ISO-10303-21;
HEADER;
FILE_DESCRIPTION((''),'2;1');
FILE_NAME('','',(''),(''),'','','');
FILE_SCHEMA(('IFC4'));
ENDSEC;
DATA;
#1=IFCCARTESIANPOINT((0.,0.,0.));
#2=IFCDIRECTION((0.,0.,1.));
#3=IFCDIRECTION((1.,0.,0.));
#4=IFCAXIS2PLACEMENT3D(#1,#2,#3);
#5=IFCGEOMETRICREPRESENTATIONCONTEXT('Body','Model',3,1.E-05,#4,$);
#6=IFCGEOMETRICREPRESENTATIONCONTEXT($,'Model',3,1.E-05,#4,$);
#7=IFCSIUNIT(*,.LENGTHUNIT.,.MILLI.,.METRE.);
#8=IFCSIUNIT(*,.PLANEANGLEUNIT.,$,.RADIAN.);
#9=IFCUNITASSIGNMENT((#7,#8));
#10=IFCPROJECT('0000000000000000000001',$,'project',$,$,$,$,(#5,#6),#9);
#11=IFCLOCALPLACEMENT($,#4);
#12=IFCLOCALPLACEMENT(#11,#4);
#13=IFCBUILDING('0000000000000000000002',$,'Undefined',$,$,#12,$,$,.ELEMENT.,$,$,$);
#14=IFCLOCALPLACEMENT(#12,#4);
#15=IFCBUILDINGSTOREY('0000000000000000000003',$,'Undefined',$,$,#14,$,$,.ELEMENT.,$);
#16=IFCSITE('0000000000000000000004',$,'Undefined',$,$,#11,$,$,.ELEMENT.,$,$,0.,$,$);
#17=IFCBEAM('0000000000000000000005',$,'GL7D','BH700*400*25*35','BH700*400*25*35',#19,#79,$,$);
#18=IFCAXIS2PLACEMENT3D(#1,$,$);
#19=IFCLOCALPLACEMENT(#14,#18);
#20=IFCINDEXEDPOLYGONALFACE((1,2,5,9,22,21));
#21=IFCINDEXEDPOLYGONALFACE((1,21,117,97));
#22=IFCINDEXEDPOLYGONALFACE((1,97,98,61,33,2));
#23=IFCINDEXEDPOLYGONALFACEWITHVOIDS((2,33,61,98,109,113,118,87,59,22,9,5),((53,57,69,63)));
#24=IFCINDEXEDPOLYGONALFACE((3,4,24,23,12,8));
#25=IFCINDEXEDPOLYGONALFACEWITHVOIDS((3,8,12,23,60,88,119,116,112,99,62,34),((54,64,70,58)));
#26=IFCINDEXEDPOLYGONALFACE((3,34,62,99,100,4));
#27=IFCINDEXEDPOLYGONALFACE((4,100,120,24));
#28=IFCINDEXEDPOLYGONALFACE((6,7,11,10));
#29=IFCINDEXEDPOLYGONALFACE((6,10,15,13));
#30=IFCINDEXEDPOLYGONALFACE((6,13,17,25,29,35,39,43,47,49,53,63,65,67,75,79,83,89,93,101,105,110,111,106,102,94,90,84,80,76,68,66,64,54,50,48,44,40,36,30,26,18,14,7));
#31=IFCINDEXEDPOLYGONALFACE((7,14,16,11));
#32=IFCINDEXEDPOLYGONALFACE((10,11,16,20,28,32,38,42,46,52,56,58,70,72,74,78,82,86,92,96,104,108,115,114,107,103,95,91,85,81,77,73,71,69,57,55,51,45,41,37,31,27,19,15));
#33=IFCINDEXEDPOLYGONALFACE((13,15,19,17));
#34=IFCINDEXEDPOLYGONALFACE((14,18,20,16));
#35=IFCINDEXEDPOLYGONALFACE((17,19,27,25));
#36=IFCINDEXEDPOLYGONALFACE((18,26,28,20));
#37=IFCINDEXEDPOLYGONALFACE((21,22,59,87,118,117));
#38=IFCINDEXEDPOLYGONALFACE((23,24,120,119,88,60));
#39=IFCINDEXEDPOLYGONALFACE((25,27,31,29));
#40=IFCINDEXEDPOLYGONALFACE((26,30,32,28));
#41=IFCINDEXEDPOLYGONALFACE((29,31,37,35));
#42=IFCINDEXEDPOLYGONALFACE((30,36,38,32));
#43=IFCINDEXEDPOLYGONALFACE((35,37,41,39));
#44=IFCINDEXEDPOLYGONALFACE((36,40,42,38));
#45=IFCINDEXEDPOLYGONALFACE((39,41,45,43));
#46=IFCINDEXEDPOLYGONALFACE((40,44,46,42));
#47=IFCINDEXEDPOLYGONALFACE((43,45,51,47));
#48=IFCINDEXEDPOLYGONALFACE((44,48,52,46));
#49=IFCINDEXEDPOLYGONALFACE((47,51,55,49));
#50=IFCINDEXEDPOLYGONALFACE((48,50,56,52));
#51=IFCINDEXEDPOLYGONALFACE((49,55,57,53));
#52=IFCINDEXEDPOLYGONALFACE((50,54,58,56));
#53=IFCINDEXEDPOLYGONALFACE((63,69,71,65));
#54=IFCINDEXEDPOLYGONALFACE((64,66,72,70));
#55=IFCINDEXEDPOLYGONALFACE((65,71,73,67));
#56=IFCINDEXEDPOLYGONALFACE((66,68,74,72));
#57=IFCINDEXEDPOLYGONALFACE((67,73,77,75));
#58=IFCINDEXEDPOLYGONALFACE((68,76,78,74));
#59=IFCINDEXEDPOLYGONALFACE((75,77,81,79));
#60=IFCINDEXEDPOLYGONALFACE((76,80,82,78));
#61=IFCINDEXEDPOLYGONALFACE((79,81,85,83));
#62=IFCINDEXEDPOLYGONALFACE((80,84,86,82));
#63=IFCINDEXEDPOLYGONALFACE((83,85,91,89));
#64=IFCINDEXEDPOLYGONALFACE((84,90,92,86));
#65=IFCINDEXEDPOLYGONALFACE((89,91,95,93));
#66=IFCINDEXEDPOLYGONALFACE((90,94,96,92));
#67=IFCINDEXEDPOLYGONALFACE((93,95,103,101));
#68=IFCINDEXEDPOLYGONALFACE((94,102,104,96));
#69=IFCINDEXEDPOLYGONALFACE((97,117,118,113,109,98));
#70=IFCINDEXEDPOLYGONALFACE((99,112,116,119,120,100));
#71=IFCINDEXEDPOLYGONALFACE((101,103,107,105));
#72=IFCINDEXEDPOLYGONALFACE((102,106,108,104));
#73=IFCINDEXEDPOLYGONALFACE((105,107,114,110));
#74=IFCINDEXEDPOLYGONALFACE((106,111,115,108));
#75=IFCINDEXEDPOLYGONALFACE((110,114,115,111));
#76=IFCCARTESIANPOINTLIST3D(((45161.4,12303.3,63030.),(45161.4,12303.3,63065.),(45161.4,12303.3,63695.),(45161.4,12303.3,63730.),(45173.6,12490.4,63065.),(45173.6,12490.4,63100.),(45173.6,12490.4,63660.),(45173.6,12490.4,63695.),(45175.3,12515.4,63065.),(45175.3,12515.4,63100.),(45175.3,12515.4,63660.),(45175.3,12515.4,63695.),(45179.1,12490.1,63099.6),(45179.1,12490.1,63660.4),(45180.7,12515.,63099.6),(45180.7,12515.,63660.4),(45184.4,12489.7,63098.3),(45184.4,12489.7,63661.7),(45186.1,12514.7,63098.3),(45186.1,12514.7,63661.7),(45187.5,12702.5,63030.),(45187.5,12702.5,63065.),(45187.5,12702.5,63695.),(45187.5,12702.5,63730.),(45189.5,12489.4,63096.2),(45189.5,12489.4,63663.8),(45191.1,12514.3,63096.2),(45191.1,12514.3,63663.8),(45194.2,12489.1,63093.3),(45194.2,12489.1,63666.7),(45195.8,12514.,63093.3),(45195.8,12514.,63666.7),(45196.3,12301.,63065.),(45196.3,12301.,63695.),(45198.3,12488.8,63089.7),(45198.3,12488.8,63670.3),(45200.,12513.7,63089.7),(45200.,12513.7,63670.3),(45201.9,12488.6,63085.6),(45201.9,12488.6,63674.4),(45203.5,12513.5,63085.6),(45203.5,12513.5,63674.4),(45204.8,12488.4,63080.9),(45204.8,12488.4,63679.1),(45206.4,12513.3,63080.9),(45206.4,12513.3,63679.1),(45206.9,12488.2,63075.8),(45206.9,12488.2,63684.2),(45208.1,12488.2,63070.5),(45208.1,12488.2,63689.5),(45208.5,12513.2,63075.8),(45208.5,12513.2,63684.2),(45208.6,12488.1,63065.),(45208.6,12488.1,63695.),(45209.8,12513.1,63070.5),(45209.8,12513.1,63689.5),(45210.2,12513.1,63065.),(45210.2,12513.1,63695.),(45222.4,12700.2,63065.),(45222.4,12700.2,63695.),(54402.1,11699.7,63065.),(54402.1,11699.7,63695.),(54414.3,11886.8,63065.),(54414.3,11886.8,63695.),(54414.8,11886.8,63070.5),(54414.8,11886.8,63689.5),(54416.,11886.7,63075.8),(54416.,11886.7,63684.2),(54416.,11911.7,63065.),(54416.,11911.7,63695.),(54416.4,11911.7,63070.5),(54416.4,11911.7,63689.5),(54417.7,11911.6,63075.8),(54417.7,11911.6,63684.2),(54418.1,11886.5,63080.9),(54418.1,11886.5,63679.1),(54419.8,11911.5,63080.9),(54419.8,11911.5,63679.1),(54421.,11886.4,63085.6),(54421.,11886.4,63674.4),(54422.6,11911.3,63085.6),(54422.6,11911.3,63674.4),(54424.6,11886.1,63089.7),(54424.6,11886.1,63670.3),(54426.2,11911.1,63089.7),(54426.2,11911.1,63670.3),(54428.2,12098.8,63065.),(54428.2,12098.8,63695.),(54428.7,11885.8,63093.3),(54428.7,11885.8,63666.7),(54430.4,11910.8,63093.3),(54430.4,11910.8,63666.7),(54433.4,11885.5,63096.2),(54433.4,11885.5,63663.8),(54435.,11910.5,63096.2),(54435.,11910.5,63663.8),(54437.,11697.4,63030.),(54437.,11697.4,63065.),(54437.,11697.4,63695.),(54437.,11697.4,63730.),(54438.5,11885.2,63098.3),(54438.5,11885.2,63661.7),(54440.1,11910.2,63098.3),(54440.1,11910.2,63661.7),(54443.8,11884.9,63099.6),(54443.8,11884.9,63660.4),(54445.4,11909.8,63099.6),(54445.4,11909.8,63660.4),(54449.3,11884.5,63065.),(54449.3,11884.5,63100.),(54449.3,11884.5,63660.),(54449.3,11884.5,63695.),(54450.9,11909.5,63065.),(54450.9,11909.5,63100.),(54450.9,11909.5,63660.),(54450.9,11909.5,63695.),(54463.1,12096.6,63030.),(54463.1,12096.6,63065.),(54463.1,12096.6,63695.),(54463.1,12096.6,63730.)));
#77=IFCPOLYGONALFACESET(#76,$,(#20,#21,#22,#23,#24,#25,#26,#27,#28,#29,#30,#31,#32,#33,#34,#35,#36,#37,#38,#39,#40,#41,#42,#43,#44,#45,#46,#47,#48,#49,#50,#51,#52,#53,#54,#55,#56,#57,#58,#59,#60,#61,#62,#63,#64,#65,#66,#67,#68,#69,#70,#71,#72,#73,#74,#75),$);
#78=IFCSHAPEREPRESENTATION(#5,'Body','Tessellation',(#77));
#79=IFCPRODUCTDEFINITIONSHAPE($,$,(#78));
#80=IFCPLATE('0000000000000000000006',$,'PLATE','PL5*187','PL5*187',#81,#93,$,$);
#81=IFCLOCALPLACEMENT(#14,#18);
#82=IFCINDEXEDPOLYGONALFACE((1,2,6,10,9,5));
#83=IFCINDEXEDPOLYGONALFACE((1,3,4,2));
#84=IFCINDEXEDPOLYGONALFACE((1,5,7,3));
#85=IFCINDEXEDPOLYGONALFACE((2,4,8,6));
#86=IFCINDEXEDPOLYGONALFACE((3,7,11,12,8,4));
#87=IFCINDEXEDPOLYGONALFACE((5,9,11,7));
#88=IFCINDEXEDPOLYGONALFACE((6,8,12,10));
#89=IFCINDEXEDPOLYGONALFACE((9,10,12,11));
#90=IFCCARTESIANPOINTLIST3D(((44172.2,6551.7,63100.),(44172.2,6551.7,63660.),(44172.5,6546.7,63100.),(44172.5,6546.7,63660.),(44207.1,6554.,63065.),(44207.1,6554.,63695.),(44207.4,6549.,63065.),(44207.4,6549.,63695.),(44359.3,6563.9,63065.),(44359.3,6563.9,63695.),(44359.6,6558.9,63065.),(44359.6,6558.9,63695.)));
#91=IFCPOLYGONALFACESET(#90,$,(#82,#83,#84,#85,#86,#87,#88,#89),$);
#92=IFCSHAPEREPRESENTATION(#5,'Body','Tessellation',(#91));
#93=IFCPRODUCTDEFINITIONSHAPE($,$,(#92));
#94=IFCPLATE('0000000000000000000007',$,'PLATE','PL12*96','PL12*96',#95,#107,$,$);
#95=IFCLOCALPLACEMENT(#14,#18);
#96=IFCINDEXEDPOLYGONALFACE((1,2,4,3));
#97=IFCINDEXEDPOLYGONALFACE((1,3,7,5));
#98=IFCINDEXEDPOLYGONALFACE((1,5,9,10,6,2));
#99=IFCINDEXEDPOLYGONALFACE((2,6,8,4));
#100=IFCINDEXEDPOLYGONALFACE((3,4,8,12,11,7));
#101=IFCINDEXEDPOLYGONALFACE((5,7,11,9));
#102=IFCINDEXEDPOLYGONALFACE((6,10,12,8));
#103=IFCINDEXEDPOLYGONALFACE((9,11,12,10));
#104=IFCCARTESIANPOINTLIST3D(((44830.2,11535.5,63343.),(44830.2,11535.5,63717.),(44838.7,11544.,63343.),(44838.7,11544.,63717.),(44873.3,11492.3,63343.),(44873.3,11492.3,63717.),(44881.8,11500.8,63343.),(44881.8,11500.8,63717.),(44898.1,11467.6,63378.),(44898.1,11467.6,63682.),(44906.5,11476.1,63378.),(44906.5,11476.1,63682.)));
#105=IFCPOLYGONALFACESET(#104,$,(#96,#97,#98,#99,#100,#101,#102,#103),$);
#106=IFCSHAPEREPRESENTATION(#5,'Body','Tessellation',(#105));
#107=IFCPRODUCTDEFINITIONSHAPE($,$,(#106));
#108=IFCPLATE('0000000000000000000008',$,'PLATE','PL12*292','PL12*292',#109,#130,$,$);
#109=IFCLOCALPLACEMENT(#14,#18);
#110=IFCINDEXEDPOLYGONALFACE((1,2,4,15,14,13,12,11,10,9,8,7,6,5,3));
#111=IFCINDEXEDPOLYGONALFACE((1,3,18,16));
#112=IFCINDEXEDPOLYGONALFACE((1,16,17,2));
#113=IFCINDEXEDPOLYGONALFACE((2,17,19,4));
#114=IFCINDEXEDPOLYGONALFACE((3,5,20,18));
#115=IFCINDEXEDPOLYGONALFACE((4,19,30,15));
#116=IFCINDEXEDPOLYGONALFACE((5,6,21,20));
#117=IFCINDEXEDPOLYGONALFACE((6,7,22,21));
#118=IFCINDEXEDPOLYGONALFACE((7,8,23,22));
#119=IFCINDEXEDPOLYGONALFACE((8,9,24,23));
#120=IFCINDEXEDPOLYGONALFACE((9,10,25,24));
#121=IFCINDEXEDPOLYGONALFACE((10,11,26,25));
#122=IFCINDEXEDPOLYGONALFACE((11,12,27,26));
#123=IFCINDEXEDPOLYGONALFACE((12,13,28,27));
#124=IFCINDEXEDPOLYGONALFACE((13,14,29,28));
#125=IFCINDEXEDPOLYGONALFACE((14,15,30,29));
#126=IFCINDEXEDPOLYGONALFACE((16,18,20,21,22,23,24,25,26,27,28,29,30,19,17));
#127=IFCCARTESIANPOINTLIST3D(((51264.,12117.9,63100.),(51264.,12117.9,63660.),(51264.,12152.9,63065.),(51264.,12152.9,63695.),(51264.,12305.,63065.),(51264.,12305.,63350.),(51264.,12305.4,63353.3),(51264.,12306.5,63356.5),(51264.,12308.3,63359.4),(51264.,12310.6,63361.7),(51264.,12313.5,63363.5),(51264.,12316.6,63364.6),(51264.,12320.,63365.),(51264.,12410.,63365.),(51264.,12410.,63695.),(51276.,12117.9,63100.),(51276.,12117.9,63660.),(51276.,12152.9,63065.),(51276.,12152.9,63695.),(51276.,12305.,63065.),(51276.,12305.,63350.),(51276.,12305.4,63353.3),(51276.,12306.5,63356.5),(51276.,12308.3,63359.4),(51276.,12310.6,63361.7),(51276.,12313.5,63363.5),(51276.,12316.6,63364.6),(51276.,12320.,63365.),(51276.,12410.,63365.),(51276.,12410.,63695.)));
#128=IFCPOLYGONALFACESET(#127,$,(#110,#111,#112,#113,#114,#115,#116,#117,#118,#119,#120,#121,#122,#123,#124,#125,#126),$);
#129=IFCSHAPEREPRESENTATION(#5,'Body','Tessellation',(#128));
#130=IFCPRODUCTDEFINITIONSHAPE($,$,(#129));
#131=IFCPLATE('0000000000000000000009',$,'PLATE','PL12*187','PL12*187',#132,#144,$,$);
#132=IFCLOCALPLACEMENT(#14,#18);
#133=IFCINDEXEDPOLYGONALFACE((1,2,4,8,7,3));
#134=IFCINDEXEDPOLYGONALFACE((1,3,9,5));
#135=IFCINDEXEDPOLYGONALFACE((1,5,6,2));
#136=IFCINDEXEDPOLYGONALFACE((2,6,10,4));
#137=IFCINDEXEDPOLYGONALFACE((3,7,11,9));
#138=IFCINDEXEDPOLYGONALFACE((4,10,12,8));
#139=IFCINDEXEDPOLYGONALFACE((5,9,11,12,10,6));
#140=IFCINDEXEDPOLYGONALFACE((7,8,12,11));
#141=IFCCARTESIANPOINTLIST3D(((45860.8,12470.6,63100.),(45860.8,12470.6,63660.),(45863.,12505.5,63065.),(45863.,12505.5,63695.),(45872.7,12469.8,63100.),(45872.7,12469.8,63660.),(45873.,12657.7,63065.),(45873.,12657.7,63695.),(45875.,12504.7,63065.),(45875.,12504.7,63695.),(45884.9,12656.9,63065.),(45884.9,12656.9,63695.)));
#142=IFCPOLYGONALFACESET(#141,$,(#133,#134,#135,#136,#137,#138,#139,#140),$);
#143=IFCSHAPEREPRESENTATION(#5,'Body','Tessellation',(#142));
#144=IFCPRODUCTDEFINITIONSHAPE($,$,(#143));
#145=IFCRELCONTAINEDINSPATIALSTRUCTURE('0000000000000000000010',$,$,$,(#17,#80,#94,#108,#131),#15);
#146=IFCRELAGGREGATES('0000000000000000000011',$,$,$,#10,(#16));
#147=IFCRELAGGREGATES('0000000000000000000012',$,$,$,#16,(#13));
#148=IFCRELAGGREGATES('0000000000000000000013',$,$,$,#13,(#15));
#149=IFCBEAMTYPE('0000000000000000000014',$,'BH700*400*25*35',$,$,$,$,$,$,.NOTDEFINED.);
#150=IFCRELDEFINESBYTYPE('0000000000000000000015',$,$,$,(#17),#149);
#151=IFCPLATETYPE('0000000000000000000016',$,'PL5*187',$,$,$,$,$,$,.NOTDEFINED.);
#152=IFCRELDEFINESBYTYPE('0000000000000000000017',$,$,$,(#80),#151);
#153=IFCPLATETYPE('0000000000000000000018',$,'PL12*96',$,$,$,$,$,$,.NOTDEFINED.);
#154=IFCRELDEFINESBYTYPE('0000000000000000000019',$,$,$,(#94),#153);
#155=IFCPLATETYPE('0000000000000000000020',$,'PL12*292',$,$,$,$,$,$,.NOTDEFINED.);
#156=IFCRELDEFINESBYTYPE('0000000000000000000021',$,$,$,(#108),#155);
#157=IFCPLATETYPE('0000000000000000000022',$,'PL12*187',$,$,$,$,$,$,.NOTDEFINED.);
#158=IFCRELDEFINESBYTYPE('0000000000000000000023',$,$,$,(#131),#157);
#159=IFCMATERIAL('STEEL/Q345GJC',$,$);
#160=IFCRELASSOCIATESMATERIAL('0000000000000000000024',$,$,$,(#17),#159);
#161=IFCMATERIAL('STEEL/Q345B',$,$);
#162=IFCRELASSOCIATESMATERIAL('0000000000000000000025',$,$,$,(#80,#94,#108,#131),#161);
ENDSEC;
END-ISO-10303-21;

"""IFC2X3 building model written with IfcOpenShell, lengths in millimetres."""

from ifc_helpers import new_model, si_unit, frame, origin_with_axes, origin_2d_with_axis, place, context, project, spatial, polyline, i_section, outline, extrude, material, type_object, element, save


model = new_model("IFC2X3")

# Units and contexts
model_context_1 = context("Model", 3, precision=1e-05, world=origin_with_axes(), identifier="Body")
model_context_2 = context("Model", 3, precision=1e-05, world=origin_with_axes())
ifc_project = project(units=[si_unit("LENGTHUNIT", "METRE", prefix="MILLI"), si_unit("PLANEANGLEUNIT", "RADIAN")], contexts=[model_context_1, model_context_2])

# Site, building, storey
site_placement = place(None, origin_with_axes())
site = spatial("IfcSite", under=ifc_project, at=site_placement, Name="Undefined", CompositionType="ELEMENT", RefElevation=0.0)
building_placement = place(site_placement, origin_with_axes())
building = spatial("IfcBuilding", under=site, at=building_placement, Name="Undefined", CompositionType="ELEMENT")
storey_placement = place(building_placement, origin_with_axes())
storey = spatial("IfcBuildingStorey", under=building, at=storey_placement, Name="Undefined", CompositionType="ELEMENT")

# Shared definitions
ifc_material_1 = material(Name="STEEL/Q345B")

# Shared definitions
ifc_material_2 = material(Name="STEEL/Q345GJC")

# Beam, openings
beam_type_1 = type_object("IfcBeamType", Name="BH700*400*25*35", PredefinedType="NOTDEFINED")
beam_1_placement = place(storey_placement, frame((55367.7, 11837.0, 63380.0), z_axis=(0.0, 0.0, 1.0), x_axis=(-0.997873, 0.065184, 0.0)))
beam_1 = element("IfcBeam", 1, at=beam_1_placement, inside=storey, type_object=beam_type_1, material=ifc_material_2, Name="GL7D", Description="BH700*400*25*35", ObjectType="BH700*400*25*35", context=model_context_1, shape_type="SweptSolid", body=[
    extrude(i_section(OverallWidth=400.0, OverallDepth=700.0, WebThickness=25.0, FlangeThickness=35.0, at=origin_2d_with_axis()), frame((10215.0, 0.0, 0.0), z_axis=(-1.0, 0.0, 0.0), x_axis=(0.0, -1.0, 0.0)), (0.0, 0.0, 1.0), 9295.4),
])
opening_1_placement = place(storey_placement, frame((55367.7, 11837.0, 63380.0), z_axis=(0.0, 0.0, 1.0), x_axis=(-0.997873, 0.065184, 0.0)))
element("IfcOpeningElement", 2, at=opening_1_placement, cuts=beam_1, ObjectType="Recess", context=model_context_1, shape_type="SweptSolid", body=[
    extrude(outline(polyline([(0.0, 0.0), (37.0, 0.0), (37.0, 35.0), (35.0, 35.0), (29.5, 34.6), (24.2, 33.3), (19.1, 31.2), (14.4, 28.3), (10.3, 24.7), (6.7, 20.6), (3.8, 15.9), (1.7, 10.8), (0.4, 5.5), (0.0, 0.0), (0.0, 0.0)])), frame((10180.0, -200.0, 315.0), z_axis=(0.0, 1.0, 0.0), x_axis=(1.0, 0.0, 0.0)), (0.0, 0.0, 1.0), 400.0),
])
opening_2_placement = place(storey_placement, frame((55367.7, 11837.0, 63380.0), z_axis=(0.0, 0.0, 1.0), x_axis=(-0.997873, 0.065184, 0.0)))
element("IfcOpeningElement", 3, at=opening_2_placement, cuts=beam_1, ObjectType="Recess", context=model_context_1, shape_type="SweptSolid", body=[
    extrude(outline(polyline([(0.0, 0.0), (37.0, 0.0), (36.6, 5.5), (35.3, 10.8), (33.2, 15.9), (30.3, 20.6), (26.7, 24.7), (22.6, 28.3), (17.9, 31.2), (12.8, 33.3), (7.5, 34.6), (2.0, 35.0), (0.0, 35.0), (0.0, 0.0)])), frame((10217.0, -200.0, -315.0), z_axis=(0.0, 1.0, 0.0), x_axis=(-1.0, 0.0, 0.0)), (0.0, 0.0, 1.0), 400.0),
])
opening_3_placement = place(storey_placement, frame((55367.7, 11837.0, 63380.0), z_axis=(0.0, 0.0, 1.0), x_axis=(-0.997873, 0.065184, 0.0)))
element("IfcOpeningElement", 4, at=opening_3_placement, cuts=beam_1, ObjectType="Recess", context=model_context_1, shape_type="SweptSolid", body=[
    extrude(outline(polyline([(0.0, 0.0), (37.0, 0.0), (37.0, 35.0), (35.0, 35.0), (29.5, 34.6), (24.2, 33.3), (19.1, 31.2), (14.4, 28.3), (10.3, 24.7), (6.7, 20.6), (3.8, 15.9), (1.7, 10.8), (0.4, 5.5), (0.0, 0.0), (0.0, 0.0)])), frame((954.6, 200.0, 315.0), z_axis=(0.0, -1.0, 0.0), x_axis=(-1.0, 0.0, 0.0)), (0.0, 0.0, 1.0), 400.0),
])
opening_4_placement = place(storey_placement, frame((55367.7, 11837.0, 63380.0), z_axis=(0.0, 0.0, 1.0), x_axis=(-0.997873, 0.065184, 0.0)))
element("IfcOpeningElement", 5, at=opening_4_placement, cuts=beam_1, ObjectType="Recess", context=model_context_1, shape_type="SweptSolid", body=[
    extrude(outline(polyline([(0.0, 0.0), (37.0, 0.0), (36.6, 5.5), (35.3, 10.8), (33.2, 15.9), (30.3, 20.6), (26.7, 24.7), (22.6, 28.3), (17.9, 31.2), (12.8, 33.3), (7.5, 34.6), (2.0, 35.0), (0.0, 35.0), (0.0, 0.0)])), frame((917.6, 200.0, -315.0), z_axis=(0.0, -1.0, 0.0), x_axis=(1.0, 0.0, 0.0)), (0.0, 0.0, 1.0), 400.0),
])
opening_5_placement = place(storey_placement, frame((55367.7, 11837.0, 63380.0), z_axis=(0.0, 0.0, 1.0), x_axis=(-0.997873, 0.065184, 0.0)))
element("IfcOpeningElement", 6, at=opening_5_placement, cuts=beam_1, ObjectType="Recess", context=model_context_1, shape_type="SweptSolid", body=[
    extrude(outline(polyline([(0.0, 0.0), (37.0, 0.0), (37.0, 35.0), (35.0, 35.0), (29.5, 34.6), (24.2, 33.3), (19.1, 31.2), (14.4, 28.3), (10.3, 24.7), (6.7, 20.6), (3.8, 15.9), (1.7, 10.8), (0.4, 5.5), (0.0, 0.0), (0.0, 0.0)])), frame((954.6, 200.0, 315.0), z_axis=(0.0, -1.0, 0.0), x_axis=(-1.0, 0.0, 0.0)), (0.0, 0.0, 1.0), 400.0),
])
opening_6_placement = place(storey_placement, frame((55367.7, 11837.0, 63380.0), z_axis=(0.0, 0.0, 1.0), x_axis=(-0.997873, 0.065184, 0.0)))
element("IfcOpeningElement", 7, at=opening_6_placement, cuts=beam_1, ObjectType="Recess", context=model_context_1, shape_type="SweptSolid", body=[
    extrude(outline(polyline([(0.0, 0.0), (37.0, 0.0), (36.6, 5.5), (35.3, 10.8), (33.2, 15.9), (30.3, 20.6), (26.7, 24.7), (22.6, 28.3), (17.9, 31.2), (12.8, 33.3), (7.5, 34.6), (2.0, 35.0), (0.0, 35.0), (0.0, 0.0)])), frame((917.6, 200.0, -315.0), z_axis=(0.0, -1.0, 0.0), x_axis=(1.0, 0.0, 0.0)), (0.0, 0.0, 1.0), 400.0),
])

# Plates
plate_type_1 = type_object("IfcPlateType", Name="PL5*187", PredefinedType="NOTDEFINED")
plate_1_placement = place(storey_placement, frame((44359.4, 6561.4, 63695.0), z_axis=(0.065171, -0.997874, 0.0), x_axis=(-0.997874, -0.065171, 0.0)))
element("IfcPlate", 8, at=plate_1_placement, inside=storey, type_object=plate_type_1, material=ifc_material_1, Name="PLATE", Description="PL5*187", ObjectType="PL5*187", context=model_context_1, shape_type="SweptSolid", body=[
    extrude(outline(polyline([(0.0, 0.0), (152.5, 0.0), (187.5, 35.0), (187.5, 595.0), (152.5, 630.0), (0.0, 630.0), (0.0, 0.0)])), frame((0.0, 0.0, -2.5), z_axis=(0.0, 0.0, 1.0), x_axis=(1.0, 0.0, 0.0)), (0.0, 0.0, 1.0), 5.0),
])
plate_type_2 = type_object("IfcPlateType", Name="PL12*96", PredefinedType="NOTDEFINED")
plate_2_placement = place(storey_placement, frame((44902.3, 11471.8, 63343.0), z_axis=(0.707107, 0.707107, 0.0), x_axis=(-0.707107, 0.707107, 0.0)))
element("IfcPlate", 9, at=plate_2_placement, inside=storey, type_object=plate_type_2, material=ifc_material_1, Name="PLATE", Description="PL12*96", ObjectType="PL12*96", context=model_context_1, shape_type="SweptSolid", body=[
    extrude(outline(polyline([(0.0, 35.0), (35.0, 0.0), (96.0, 0.0), (96.0, 374.0), (35.0, 374.0), (0.0, 339.0), (0.0, 35.0)])), frame((0.0, 0.0, -6.0), z_axis=(0.0, 0.0, 1.0), x_axis=(1.0, 0.0, 0.0)), (0.0, 0.0, 1.0), 12.0),
])
plate_type_3 = type_object("IfcPlateType", Name="PL12*292", PredefinedType="NOTDEFINED")
plate_3_placement = place(storey_placement, frame((51270.0, 12410.0, 63695.0), z_axis=(1.0, 0.0, 0.0), x_axis=(0.0, -1.0, 0.0)))
element("IfcPlate", 10, at=plate_3_placement, inside=storey, type_object=plate_type_3, material=ifc_material_1, Name="PLATE", Description="PL12*292", ObjectType="PL12*292", context=model_context_1, shape_type="SweptSolid", body=[
    extrude(outline(polyline([(0.0, 0.0), (257.2, 0.0), (292.2, 35.0), (292.2, 595.0), (257.2, 630.0), (105.1, 630.0), (105.1, 345.0), (104.7, 341.7), (103.6, 338.5), (101.8, 335.6), (99.4, 333.3), (96.6, 331.5), (93.4, 330.4), (90.1, 330.0), (0.0, 330.0), (0.0, 0.0)])), frame((0.0, 0.0, -6.0), z_axis=(0.0, 0.0, 1.0), x_axis=(1.0, 0.0, 0.0)), (0.0, 0.0, 1.0), 12.0),
])
plate_type_4 = type_object("IfcPlateType", Name="PL12*187", PredefinedType="NOTDEFINED")
for number, where, z_axis, x_axis, name in (
    (11, (45866.7, 12470.2, 63065.0), (0.997873, -0.065183, 0.0), (0.065184, 0.997873, 0.0), "PLATE"),
):
    element("IfcPlate", number, at=place(storey_placement, frame(where, z_axis=z_axis, x_axis=x_axis)), inside=storey, type_object=plate_type_4, material=ifc_material_1, Name=name, Description="PL12*187", ObjectType="PL12*187", context=model_context_1, shape_type="SweptSolid", body=[
        extrude(outline(polyline([(0.0, 35.0), (35.0, 0.0), (187.5, 0.0), (187.5, 630.0), (35.0, 630.0), (0.0, 595.0), (0.0, 35.0)])), frame((0.0, 0.0, -6.0), z_axis=(0.0, 0.0, 1.0), x_axis=(1.0, 0.0, 0.0)), (0.0, 0.0, 1.0), 12.0),
    ])

save(model, "model.ifc")
